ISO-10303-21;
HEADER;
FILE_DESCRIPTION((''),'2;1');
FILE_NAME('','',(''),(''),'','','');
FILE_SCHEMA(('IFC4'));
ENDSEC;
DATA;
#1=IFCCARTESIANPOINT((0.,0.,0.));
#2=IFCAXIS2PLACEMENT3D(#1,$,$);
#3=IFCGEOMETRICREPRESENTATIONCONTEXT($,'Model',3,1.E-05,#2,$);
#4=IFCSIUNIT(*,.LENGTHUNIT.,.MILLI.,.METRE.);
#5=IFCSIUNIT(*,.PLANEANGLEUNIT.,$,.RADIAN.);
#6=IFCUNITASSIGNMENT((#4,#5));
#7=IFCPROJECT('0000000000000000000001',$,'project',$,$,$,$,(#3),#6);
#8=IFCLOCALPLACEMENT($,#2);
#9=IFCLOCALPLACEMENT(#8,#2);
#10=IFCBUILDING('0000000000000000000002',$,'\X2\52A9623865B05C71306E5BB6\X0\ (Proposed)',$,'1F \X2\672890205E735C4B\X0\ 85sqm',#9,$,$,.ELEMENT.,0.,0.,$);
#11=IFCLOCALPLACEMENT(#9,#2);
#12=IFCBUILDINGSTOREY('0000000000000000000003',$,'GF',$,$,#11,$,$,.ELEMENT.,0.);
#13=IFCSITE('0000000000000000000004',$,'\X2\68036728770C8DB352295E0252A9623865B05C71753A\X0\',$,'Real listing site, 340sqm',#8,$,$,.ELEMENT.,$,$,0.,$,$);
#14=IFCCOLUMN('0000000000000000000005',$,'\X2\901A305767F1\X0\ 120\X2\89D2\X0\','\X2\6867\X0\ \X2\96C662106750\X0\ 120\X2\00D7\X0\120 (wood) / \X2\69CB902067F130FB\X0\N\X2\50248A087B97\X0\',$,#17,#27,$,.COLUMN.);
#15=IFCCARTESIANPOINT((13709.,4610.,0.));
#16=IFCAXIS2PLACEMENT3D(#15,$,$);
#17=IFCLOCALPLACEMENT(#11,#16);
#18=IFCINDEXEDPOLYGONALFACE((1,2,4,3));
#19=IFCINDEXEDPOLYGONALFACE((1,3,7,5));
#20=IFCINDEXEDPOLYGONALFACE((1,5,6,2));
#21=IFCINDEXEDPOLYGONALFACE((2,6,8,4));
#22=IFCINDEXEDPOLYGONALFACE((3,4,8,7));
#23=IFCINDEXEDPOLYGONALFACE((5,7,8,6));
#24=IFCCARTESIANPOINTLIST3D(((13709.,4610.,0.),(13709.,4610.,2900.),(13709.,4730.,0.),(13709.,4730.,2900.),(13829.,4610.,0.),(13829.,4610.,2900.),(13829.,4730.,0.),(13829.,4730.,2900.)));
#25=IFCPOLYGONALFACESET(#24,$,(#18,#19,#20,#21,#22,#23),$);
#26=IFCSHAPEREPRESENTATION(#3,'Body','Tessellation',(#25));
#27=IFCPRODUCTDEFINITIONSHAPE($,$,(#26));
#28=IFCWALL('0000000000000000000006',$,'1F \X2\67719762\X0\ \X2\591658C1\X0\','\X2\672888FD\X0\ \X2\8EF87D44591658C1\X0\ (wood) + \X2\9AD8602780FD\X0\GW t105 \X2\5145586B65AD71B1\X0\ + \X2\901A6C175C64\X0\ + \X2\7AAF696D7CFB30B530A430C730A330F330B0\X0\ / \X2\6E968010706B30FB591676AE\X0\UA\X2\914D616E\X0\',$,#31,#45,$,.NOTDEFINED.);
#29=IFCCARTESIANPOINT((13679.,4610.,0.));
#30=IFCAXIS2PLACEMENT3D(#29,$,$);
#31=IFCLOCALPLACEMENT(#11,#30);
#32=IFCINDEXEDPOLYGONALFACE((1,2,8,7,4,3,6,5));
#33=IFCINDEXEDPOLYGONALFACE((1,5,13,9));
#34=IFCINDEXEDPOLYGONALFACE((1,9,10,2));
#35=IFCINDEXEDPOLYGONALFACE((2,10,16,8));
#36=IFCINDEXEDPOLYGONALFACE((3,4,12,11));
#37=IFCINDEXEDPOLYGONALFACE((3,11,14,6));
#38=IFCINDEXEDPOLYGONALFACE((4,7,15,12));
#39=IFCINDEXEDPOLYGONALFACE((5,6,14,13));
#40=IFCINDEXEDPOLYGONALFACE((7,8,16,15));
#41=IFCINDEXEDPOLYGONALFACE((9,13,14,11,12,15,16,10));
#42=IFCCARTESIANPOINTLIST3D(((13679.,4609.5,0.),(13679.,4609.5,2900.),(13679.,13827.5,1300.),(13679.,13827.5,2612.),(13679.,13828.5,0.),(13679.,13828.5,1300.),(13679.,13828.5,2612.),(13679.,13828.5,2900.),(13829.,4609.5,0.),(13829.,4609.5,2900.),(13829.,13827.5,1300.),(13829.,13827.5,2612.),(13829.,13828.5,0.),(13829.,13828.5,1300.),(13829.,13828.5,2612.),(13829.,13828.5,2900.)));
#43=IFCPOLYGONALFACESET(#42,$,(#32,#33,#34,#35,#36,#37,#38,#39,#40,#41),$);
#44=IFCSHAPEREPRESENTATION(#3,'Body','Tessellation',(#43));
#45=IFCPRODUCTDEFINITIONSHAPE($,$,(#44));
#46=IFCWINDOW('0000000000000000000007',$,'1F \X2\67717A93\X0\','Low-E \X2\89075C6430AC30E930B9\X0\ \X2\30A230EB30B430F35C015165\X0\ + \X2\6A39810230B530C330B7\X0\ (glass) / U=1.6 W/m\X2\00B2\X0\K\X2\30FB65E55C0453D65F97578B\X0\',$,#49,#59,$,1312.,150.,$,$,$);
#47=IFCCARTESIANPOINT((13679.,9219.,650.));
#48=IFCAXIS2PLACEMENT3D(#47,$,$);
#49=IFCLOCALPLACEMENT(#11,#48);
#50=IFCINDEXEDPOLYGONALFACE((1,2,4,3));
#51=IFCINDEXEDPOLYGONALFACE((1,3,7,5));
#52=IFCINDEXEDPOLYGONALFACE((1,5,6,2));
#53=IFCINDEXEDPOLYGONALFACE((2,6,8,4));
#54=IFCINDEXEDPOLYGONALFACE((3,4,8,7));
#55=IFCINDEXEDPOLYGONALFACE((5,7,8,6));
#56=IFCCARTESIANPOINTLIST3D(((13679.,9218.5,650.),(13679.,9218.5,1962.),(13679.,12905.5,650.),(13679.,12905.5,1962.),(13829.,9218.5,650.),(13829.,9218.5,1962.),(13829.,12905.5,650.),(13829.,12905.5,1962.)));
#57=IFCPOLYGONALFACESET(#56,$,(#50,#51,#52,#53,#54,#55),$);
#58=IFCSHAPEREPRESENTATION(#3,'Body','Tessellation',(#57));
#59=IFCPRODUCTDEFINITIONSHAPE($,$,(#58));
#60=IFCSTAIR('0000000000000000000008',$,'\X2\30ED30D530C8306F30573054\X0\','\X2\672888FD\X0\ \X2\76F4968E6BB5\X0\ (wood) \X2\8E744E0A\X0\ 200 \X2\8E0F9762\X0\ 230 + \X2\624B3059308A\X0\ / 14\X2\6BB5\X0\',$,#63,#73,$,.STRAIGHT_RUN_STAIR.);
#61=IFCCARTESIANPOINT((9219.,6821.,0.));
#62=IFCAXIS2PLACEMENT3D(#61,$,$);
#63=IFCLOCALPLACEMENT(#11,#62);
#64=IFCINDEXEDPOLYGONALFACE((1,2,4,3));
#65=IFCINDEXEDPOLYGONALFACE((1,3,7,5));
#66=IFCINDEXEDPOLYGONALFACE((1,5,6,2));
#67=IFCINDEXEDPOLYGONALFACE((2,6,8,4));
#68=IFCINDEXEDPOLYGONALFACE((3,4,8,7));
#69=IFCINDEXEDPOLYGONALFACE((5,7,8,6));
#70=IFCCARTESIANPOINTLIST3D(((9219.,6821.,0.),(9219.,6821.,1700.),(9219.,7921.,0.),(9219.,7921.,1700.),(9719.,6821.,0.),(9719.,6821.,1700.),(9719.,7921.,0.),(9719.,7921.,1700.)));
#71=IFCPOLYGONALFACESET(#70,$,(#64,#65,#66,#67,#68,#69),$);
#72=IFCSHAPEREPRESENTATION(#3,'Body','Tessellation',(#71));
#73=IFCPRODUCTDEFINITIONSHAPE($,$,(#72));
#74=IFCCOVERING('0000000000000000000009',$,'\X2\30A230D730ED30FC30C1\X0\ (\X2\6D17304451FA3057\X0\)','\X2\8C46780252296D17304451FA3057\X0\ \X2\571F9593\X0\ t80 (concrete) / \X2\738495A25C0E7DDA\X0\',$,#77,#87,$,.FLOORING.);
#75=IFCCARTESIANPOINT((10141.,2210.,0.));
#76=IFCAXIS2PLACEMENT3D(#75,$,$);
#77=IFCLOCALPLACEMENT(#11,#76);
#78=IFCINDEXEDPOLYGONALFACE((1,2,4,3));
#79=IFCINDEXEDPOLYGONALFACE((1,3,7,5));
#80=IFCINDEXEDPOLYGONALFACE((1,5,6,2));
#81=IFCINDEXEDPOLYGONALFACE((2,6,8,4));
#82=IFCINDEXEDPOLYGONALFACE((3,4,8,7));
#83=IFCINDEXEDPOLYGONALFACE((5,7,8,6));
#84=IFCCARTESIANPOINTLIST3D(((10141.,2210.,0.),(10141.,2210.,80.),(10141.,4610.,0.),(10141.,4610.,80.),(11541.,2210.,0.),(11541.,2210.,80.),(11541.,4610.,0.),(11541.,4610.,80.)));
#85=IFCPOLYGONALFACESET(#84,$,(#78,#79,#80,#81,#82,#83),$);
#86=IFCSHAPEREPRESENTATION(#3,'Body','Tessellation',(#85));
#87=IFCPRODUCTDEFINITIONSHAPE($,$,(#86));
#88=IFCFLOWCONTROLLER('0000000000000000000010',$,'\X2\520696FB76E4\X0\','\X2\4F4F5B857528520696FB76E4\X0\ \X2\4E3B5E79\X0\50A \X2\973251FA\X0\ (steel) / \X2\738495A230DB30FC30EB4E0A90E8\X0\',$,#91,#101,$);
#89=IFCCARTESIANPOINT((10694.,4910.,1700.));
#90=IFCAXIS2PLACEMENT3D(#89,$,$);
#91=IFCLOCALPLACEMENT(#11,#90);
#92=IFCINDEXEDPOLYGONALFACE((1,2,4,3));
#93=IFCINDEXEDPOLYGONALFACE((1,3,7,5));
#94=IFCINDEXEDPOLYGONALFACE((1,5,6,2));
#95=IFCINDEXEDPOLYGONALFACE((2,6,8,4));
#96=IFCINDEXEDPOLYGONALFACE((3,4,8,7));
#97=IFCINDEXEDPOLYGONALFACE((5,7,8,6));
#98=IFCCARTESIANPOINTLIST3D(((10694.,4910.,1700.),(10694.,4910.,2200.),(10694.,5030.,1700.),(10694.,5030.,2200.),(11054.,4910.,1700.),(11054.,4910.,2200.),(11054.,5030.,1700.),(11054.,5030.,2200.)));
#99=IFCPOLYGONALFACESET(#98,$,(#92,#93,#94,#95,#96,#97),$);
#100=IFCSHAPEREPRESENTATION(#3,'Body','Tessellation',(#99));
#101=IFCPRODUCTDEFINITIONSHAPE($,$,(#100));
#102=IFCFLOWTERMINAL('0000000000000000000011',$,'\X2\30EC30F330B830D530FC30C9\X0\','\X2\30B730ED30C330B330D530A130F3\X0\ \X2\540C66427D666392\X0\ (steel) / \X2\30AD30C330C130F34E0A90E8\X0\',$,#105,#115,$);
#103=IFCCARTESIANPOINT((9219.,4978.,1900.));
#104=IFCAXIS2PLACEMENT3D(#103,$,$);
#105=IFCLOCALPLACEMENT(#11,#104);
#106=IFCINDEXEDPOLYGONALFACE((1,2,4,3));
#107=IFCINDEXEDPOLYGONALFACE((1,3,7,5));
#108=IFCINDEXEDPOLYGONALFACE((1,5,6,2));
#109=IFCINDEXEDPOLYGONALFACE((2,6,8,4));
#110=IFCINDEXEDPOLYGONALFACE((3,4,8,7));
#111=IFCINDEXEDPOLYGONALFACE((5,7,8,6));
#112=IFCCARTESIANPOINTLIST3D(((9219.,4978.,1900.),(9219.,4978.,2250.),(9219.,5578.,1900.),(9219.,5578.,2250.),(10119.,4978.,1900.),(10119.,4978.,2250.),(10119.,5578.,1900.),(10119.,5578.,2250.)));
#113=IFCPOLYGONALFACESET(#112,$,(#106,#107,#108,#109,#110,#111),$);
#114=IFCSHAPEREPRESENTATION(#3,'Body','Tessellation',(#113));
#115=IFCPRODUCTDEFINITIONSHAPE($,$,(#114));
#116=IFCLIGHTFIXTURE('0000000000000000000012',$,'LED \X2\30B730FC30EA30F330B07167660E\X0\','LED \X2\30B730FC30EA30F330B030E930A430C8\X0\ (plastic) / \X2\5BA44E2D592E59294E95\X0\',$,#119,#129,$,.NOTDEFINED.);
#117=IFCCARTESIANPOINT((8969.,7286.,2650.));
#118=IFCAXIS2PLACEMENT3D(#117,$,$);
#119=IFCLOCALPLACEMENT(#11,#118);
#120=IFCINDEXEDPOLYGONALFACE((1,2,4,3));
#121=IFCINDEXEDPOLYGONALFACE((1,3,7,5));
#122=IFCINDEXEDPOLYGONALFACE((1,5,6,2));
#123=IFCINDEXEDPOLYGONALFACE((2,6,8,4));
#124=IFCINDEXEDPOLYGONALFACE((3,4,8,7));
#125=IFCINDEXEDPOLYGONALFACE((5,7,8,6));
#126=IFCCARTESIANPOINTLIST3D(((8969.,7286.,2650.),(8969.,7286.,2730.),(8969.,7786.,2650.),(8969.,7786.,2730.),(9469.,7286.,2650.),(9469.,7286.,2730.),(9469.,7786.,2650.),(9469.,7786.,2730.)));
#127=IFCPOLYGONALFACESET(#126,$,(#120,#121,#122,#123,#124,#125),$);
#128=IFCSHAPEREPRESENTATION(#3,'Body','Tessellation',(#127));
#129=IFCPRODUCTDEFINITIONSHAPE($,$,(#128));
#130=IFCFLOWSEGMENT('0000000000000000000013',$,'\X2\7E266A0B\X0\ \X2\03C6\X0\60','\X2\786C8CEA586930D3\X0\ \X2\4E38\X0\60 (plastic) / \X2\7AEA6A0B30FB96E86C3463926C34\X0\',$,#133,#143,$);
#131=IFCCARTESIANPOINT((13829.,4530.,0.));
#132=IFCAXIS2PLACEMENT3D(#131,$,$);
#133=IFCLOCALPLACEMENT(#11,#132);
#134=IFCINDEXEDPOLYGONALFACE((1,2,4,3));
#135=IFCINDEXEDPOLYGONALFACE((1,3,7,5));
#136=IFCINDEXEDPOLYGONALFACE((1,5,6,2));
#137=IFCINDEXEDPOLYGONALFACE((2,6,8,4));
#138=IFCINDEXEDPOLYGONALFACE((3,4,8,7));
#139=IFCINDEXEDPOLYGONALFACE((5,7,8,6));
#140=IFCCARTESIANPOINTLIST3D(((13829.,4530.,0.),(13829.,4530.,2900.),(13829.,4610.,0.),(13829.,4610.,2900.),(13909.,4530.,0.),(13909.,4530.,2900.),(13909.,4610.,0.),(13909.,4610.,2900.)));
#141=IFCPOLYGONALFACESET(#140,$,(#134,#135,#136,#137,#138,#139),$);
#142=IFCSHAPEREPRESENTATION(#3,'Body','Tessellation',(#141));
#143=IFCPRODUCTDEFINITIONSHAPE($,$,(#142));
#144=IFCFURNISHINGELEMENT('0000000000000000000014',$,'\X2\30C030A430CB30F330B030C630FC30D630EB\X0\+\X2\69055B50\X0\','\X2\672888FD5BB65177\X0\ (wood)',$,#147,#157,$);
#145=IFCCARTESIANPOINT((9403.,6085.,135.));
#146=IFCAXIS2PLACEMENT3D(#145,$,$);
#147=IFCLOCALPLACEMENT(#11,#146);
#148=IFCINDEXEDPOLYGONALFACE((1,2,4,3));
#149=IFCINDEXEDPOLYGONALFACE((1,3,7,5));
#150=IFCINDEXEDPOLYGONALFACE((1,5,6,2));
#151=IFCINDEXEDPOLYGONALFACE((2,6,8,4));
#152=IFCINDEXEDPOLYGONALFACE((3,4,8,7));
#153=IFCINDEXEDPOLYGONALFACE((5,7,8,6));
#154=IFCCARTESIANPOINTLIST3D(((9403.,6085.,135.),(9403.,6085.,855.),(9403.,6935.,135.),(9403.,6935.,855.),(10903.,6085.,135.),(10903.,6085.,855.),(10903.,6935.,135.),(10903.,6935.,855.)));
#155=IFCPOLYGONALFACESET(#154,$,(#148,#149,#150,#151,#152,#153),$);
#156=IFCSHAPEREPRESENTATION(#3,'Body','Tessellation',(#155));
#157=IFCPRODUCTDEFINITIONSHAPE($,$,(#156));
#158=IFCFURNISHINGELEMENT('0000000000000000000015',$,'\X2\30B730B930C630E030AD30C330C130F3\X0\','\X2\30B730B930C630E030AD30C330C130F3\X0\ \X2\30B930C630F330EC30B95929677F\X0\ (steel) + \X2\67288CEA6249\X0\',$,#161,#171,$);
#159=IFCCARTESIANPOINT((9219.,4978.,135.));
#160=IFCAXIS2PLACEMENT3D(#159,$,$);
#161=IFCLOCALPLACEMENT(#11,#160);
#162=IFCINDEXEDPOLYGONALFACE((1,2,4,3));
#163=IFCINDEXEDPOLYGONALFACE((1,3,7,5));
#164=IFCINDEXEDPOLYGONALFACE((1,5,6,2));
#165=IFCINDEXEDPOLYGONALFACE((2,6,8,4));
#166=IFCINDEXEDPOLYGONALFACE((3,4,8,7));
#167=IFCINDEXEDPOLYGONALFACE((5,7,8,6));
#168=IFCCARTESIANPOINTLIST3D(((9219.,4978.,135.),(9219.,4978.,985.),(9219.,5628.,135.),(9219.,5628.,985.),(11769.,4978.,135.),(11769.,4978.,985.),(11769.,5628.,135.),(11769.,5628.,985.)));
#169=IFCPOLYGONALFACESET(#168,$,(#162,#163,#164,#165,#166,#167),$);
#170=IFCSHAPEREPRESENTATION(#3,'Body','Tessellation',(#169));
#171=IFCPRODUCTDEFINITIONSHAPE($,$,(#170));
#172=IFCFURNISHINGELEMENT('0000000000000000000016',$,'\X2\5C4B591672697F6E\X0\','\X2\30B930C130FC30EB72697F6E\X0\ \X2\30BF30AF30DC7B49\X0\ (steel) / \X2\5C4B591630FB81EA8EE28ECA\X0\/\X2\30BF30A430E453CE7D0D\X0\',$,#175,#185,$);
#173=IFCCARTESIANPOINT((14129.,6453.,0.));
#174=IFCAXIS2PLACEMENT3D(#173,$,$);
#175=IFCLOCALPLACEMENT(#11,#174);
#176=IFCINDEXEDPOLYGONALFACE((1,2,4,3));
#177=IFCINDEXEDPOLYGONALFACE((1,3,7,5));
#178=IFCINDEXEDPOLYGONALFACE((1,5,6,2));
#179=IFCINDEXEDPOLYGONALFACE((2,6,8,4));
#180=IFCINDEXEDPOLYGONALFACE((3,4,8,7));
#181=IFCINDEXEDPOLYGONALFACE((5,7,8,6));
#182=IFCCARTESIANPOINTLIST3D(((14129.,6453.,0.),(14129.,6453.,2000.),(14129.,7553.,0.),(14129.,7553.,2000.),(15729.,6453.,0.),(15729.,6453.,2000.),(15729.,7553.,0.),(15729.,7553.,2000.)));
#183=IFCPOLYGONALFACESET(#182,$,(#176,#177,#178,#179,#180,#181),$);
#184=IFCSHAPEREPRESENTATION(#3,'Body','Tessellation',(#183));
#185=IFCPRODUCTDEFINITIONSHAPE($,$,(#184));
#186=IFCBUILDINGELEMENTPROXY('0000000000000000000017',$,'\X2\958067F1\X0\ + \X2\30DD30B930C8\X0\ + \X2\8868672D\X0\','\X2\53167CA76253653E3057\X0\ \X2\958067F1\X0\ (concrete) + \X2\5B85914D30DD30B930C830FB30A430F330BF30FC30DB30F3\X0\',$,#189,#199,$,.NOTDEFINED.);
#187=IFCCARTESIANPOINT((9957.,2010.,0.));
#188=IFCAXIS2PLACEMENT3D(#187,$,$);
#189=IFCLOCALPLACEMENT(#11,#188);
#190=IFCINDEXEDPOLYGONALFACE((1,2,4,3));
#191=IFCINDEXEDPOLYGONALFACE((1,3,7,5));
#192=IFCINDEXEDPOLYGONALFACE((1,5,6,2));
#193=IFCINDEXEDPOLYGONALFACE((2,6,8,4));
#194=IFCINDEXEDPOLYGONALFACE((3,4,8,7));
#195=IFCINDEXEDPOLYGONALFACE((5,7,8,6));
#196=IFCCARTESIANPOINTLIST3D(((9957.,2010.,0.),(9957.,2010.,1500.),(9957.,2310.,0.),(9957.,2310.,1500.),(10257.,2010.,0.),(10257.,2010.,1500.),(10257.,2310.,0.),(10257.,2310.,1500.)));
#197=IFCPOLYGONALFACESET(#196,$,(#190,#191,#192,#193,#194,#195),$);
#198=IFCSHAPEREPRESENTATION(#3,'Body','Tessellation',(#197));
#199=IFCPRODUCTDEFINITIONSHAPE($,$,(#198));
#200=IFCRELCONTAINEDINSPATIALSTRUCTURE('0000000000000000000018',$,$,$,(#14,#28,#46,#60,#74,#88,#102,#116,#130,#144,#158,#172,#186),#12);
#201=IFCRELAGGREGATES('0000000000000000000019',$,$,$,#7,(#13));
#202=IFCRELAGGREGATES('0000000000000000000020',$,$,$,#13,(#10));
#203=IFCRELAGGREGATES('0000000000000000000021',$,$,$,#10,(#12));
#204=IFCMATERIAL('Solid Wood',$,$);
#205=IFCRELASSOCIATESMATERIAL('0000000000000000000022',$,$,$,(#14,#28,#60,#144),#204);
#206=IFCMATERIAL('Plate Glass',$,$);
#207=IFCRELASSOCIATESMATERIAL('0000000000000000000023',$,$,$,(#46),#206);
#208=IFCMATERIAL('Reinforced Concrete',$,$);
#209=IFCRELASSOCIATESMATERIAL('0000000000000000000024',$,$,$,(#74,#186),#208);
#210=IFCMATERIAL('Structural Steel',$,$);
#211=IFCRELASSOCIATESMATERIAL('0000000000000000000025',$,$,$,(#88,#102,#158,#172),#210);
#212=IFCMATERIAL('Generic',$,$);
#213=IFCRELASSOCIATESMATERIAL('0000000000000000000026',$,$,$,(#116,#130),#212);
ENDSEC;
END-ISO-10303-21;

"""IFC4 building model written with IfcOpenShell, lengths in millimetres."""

from ifc_helpers import new_model, si_unit, frame, frame_2d, origin, place, context, project, spatial, rectangle, extrude, material, element, fill, save


model = new_model("IFC4")

# Units and contexts
model_context = context("Model", 3, precision=1e-05, world=origin())
ifc_project = project(units=[si_unit("LENGTHUNIT", "METRE", prefix="MILLI"), si_unit("PLANEANGLEUNIT", "RADIAN")], contexts=[model_context])

# Site, building, storey
site_placement = place(None, origin())
site = spatial("IfcSite", under=ifc_project, at=site_placement, Name="栃木県足利市助戸新山町", ObjectType="Real listing site, 340sqm", CompositionType="ELEMENT", RefElevation=0.0)
building_placement = place(site_placement, origin())
building = spatial("IfcBuilding", under=site, at=building_placement, Name="助戸新山の家 (Proposed)", ObjectType="1F 木造平屋 85sqm", CompositionType="ELEMENT", ElevationOfRefHeight=0.0, ElevationOfTerrain=0.0)
storey_placement = place(building_placement, origin())
storey = spatial("IfcBuildingStorey", under=building, at=storey_placement, Name="GF", CompositionType="ELEMENT", Elevation=0.0)

# Column
ifc_material_1 = material(Name="Solid Wood")
column_1_placement = place(storey_placement, frame((13709.0, 4610.0, 0.0)))
element("IfcColumn", 1, at=column_1_placement, inside=storey, material=ifc_material_1, Name="通し柱 120角", Description="桧 集成材 120×120 (wood) / 構造柱・N値計算", PredefinedType="COLUMN", context=model_context, shape_type="SweptSolid", body=[
    extrude(rectangle(XDim=120.0, YDim=120.0, at=frame_2d((60.0, 60.0))), frame((13709.0, 4610.0, 0.0)), (0.0, 0.0, 1.0), 2900.0),
])

# Wall, opening, window
wall_1_placement = place(storey_placement, frame((13679.0, 4610.0, 0.0)))
wall_1 = element("IfcWall", 2, at=wall_1_placement, inside=storey, material=ifc_material_1, Name="1F 東面 外壁", Description="木製 軸組外壁 (wood) + 高性能GW t105 充填断熱 + 通気層 + 窯業系サイディング / 準耐火・外皮UA配慮", PredefinedType="NOTDEFINED", context=model_context, shape_type="SweptSolid", body=[
    extrude(rectangle(XDim=150.0, YDim=9219.0, at=frame_2d((75.0, 4609.0))), frame((13679.0, 4610.0, 0.0)), (0.0, 0.0, 1.0), 2900.0),
])
opening_placement = place(storey_placement, frame((13679.0, 9219.0, 650.0)))
opening = element("IfcOpeningElement", 3, at=opening_placement, cuts=wall_1, PredefinedType="NOTDEFINED", context=model_context, shape_type="SweptSolid", body=[
    extrude(rectangle(XDim=150.0, YDim=3687.0, at=frame_2d((75.0, 1843.0))), frame((13679.0, 9219.0, 650.0)), (0.0, 0.0, 1.0), 1312.0),
])
ifc_material_2 = material(Name="Plate Glass")
window_placement = place(storey_placement, frame((13679.0, 9219.0, 650.0)))
window = element("IfcWindow", 4, at=window_placement, inside=storey, material=ifc_material_2, Name="1F 東窓", Description="Low-E 複層ガラス アルゴン封入 + 樹脂サッシ (glass) / U=1.6 W/m²K・日射取得型", OverallHeight=1312.0, OverallWidth=150.0, context=model_context, shape_type="SweptSolid", body=[
    extrude(rectangle(XDim=150.0, YDim=3687.0, at=frame_2d((75.0, 1843.0))), frame((13679.0, 9219.0, 650.0)), (0.0, 0.0, 1.0), 1312.0),
])
fill(opening, window)

# Stair
stair_placement = place(storey_placement, frame((9219.0, 6821.0, 0.0)))
element("IfcStair", 5, at=stair_placement, inside=storey, material=ifc_material_1, Name="ロフトはしご", Description="木製 直階段 (wood) 蹴上 200 踏面 230 + 手すり / 14段", PredefinedType="STRAIGHT_RUN_STAIR", context=model_context, shape_type="SweptSolid", body=[
    extrude(rectangle(XDim=500.0, YDim=1100.0, at=frame_2d((250.0, 550.0))), frame((9219.0, 6821.0, 0.0)), (0.0, 0.0, 1.0), 1700.0),
])

# Covering
ifc_material_3 = material(Name="Reinforced Concrete")
covering_placement = place(storey_placement, frame((10141.0, 2210.0, 0.0)))
element("IfcCovering", 6, at=covering_placement, inside=storey, material=ifc_material_3, Name="アプローチ (洗い出し)", Description="豆砂利洗い出し 土間 t80 (concrete) / 玄関導線", PredefinedType="FLOORING", context=model_context, shape_type="SweptSolid", body=[
    extrude(rectangle(XDim=1400.0, YDim=2400.0, at=frame_2d((700.0, 1200.0))), frame((10141.0, 2210.0, 0.0)), (0.0, 0.0, 1.0), 80.0),
])

# Flow controller
ifc_material_4 = material(Name="Structural Steel")
flow_controller_placement = place(storey_placement, frame((10694.0, 4910.0, 1700.0)))
element("IfcFlowController", 7, at=flow_controller_placement, inside=storey, material=ifc_material_4, Name="分電盤", Description="住宅用分電盤 主幹50A 露出 (steel) / 玄関ホール上部", context=model_context, shape_type="SweptSolid", body=[
    extrude(rectangle(XDim=360.0, YDim=120.0, at=frame_2d((180.0, 60.0))), frame((10694.0, 4910.0, 1700.0)), (0.0, 0.0, 1.0), 500.0),
])

# Flow terminal
flow_terminal_placement = place(storey_placement, frame((9219.0, 4978.0, 1900.0)))
element("IfcFlowTerminal", 8, at=flow_terminal_placement, inside=storey, material=ifc_material_4, Name="レンジフード", Description="シロッコファン 同時給排 (steel) / キッチン上部", context=model_context, shape_type="SweptSolid", body=[
    extrude(rectangle(XDim=900.0, YDim=600.0, at=frame_2d((450.0, 300.0))), frame((9219.0, 4978.0, 1900.0)), (0.0, 0.0, 1.0), 350.0),
])

# Light fixture
ifc_material_5 = material(Name="Generic")
light_fixture_placement = place(storey_placement, frame((8969.0, 7286.0, 2650.0)))
element("IfcLightFixture", 9, at=light_fixture_placement, inside=storey, material=ifc_material_5, Name="LED シーリング照明", Description="LED シーリングライト (plastic) / 室中央天井", PredefinedType="NOTDEFINED", context=model_context, shape_type="SweptSolid", body=[
    extrude(rectangle(XDim=500.0, YDim=500.0, at=frame_2d((250.0, 250.0))), frame((8969.0, 7286.0, 2650.0)), (0.0, 0.0, 1.0), 80.0),
])

# Flow segment
flow_segment_placement = place(storey_placement, frame((13829.0, 4530.0, 0.0)))
element("IfcFlowSegment", 10, at=flow_segment_placement, inside=storey, material=ifc_material_5, Name="縦樋 φ60", Description="硬質塩ビ 丸60 (plastic) / 竪樋・雨水排水", context=model_context, shape_type="SweptSolid", body=[
    extrude(rectangle(XDim=80.0, YDim=80.0, at=frame_2d((40.0, 40.0))), frame((13829.0, 4530.0, 0.0)), (0.0, 0.0, 1.0), 2900.0),
])

# Furnishing elements
furnishing_1_placement = place(storey_placement, frame((9403.0, 6085.0, 135.0)))
element("IfcFurnishingElement", 11, at=furnishing_1_placement, inside=storey, material=ifc_material_1, Name="ダイニングテーブル+椅子", Description="木製家具 (wood)", context=model_context, shape_type="SweptSolid", body=[
    extrude(rectangle(XDim=1500.0, YDim=850.0, at=frame_2d((750.0, 425.0))), frame((9403.0, 6085.0, 135.0)), (0.0, 0.0, 1.0), 720.0),
])
furnishing_2_placement = place(storey_placement, frame((9219.0, 4978.0, 135.0)))
element("IfcFurnishingElement", 12, at=furnishing_2_placement, inside=storey, material=ifc_material_4, Name="システムキッチン", Description="システムキッチン ステンレス天板 (steel) + 木質扉", context=model_context, shape_type="SweptSolid", body=[
    extrude(rectangle(XDim=2550.0, YDim=650.0, at=frame_2d((1275.0, 325.0))), frame((9219.0, 4978.0, 135.0)), (0.0, 0.0, 1.0), 850.0),
])
furnishing_3_placement = place(storey_placement, frame((14129.0, 6453.0, 0.0)))
element("IfcFurnishingElement", 13, at=furnishing_3_placement, inside=storey, material=ifc_material_4, Name="屋外物置", Description="スチール物置 タクボ等 (steel) / 屋外・自転車/タイヤ収納", context=model_context, shape_type="SweptSolid", body=[
    extrude(rectangle(XDim=1600.0, YDim=1100.0, at=frame_2d((800.0, 550.0))), frame((14129.0, 6453.0, 0.0)), (0.0, 0.0, 1.0), 2000.0),
])

# Building element proxy
proxy_placement = place(storey_placement, frame((9957.0, 2010.0, 0.0)))
element("IfcBuildingElementProxy", 14, at=proxy_placement, inside=storey, material=ifc_material_3, Name="門柱 + ポスト + 表札", Description="化粧打放し 門柱 (concrete) + 宅配ポスト・インターホン", PredefinedType="NOTDEFINED", context=model_context, shape_type="SweptSolid", body=[
    extrude(rectangle(XDim=300.0, YDim=300.0, at=frame_2d((150.0, 150.0))), frame((9957.0, 2010.0, 0.0)), (0.0, 0.0, 1.0), 1500.0),
])

save(model, "model.ifc")
